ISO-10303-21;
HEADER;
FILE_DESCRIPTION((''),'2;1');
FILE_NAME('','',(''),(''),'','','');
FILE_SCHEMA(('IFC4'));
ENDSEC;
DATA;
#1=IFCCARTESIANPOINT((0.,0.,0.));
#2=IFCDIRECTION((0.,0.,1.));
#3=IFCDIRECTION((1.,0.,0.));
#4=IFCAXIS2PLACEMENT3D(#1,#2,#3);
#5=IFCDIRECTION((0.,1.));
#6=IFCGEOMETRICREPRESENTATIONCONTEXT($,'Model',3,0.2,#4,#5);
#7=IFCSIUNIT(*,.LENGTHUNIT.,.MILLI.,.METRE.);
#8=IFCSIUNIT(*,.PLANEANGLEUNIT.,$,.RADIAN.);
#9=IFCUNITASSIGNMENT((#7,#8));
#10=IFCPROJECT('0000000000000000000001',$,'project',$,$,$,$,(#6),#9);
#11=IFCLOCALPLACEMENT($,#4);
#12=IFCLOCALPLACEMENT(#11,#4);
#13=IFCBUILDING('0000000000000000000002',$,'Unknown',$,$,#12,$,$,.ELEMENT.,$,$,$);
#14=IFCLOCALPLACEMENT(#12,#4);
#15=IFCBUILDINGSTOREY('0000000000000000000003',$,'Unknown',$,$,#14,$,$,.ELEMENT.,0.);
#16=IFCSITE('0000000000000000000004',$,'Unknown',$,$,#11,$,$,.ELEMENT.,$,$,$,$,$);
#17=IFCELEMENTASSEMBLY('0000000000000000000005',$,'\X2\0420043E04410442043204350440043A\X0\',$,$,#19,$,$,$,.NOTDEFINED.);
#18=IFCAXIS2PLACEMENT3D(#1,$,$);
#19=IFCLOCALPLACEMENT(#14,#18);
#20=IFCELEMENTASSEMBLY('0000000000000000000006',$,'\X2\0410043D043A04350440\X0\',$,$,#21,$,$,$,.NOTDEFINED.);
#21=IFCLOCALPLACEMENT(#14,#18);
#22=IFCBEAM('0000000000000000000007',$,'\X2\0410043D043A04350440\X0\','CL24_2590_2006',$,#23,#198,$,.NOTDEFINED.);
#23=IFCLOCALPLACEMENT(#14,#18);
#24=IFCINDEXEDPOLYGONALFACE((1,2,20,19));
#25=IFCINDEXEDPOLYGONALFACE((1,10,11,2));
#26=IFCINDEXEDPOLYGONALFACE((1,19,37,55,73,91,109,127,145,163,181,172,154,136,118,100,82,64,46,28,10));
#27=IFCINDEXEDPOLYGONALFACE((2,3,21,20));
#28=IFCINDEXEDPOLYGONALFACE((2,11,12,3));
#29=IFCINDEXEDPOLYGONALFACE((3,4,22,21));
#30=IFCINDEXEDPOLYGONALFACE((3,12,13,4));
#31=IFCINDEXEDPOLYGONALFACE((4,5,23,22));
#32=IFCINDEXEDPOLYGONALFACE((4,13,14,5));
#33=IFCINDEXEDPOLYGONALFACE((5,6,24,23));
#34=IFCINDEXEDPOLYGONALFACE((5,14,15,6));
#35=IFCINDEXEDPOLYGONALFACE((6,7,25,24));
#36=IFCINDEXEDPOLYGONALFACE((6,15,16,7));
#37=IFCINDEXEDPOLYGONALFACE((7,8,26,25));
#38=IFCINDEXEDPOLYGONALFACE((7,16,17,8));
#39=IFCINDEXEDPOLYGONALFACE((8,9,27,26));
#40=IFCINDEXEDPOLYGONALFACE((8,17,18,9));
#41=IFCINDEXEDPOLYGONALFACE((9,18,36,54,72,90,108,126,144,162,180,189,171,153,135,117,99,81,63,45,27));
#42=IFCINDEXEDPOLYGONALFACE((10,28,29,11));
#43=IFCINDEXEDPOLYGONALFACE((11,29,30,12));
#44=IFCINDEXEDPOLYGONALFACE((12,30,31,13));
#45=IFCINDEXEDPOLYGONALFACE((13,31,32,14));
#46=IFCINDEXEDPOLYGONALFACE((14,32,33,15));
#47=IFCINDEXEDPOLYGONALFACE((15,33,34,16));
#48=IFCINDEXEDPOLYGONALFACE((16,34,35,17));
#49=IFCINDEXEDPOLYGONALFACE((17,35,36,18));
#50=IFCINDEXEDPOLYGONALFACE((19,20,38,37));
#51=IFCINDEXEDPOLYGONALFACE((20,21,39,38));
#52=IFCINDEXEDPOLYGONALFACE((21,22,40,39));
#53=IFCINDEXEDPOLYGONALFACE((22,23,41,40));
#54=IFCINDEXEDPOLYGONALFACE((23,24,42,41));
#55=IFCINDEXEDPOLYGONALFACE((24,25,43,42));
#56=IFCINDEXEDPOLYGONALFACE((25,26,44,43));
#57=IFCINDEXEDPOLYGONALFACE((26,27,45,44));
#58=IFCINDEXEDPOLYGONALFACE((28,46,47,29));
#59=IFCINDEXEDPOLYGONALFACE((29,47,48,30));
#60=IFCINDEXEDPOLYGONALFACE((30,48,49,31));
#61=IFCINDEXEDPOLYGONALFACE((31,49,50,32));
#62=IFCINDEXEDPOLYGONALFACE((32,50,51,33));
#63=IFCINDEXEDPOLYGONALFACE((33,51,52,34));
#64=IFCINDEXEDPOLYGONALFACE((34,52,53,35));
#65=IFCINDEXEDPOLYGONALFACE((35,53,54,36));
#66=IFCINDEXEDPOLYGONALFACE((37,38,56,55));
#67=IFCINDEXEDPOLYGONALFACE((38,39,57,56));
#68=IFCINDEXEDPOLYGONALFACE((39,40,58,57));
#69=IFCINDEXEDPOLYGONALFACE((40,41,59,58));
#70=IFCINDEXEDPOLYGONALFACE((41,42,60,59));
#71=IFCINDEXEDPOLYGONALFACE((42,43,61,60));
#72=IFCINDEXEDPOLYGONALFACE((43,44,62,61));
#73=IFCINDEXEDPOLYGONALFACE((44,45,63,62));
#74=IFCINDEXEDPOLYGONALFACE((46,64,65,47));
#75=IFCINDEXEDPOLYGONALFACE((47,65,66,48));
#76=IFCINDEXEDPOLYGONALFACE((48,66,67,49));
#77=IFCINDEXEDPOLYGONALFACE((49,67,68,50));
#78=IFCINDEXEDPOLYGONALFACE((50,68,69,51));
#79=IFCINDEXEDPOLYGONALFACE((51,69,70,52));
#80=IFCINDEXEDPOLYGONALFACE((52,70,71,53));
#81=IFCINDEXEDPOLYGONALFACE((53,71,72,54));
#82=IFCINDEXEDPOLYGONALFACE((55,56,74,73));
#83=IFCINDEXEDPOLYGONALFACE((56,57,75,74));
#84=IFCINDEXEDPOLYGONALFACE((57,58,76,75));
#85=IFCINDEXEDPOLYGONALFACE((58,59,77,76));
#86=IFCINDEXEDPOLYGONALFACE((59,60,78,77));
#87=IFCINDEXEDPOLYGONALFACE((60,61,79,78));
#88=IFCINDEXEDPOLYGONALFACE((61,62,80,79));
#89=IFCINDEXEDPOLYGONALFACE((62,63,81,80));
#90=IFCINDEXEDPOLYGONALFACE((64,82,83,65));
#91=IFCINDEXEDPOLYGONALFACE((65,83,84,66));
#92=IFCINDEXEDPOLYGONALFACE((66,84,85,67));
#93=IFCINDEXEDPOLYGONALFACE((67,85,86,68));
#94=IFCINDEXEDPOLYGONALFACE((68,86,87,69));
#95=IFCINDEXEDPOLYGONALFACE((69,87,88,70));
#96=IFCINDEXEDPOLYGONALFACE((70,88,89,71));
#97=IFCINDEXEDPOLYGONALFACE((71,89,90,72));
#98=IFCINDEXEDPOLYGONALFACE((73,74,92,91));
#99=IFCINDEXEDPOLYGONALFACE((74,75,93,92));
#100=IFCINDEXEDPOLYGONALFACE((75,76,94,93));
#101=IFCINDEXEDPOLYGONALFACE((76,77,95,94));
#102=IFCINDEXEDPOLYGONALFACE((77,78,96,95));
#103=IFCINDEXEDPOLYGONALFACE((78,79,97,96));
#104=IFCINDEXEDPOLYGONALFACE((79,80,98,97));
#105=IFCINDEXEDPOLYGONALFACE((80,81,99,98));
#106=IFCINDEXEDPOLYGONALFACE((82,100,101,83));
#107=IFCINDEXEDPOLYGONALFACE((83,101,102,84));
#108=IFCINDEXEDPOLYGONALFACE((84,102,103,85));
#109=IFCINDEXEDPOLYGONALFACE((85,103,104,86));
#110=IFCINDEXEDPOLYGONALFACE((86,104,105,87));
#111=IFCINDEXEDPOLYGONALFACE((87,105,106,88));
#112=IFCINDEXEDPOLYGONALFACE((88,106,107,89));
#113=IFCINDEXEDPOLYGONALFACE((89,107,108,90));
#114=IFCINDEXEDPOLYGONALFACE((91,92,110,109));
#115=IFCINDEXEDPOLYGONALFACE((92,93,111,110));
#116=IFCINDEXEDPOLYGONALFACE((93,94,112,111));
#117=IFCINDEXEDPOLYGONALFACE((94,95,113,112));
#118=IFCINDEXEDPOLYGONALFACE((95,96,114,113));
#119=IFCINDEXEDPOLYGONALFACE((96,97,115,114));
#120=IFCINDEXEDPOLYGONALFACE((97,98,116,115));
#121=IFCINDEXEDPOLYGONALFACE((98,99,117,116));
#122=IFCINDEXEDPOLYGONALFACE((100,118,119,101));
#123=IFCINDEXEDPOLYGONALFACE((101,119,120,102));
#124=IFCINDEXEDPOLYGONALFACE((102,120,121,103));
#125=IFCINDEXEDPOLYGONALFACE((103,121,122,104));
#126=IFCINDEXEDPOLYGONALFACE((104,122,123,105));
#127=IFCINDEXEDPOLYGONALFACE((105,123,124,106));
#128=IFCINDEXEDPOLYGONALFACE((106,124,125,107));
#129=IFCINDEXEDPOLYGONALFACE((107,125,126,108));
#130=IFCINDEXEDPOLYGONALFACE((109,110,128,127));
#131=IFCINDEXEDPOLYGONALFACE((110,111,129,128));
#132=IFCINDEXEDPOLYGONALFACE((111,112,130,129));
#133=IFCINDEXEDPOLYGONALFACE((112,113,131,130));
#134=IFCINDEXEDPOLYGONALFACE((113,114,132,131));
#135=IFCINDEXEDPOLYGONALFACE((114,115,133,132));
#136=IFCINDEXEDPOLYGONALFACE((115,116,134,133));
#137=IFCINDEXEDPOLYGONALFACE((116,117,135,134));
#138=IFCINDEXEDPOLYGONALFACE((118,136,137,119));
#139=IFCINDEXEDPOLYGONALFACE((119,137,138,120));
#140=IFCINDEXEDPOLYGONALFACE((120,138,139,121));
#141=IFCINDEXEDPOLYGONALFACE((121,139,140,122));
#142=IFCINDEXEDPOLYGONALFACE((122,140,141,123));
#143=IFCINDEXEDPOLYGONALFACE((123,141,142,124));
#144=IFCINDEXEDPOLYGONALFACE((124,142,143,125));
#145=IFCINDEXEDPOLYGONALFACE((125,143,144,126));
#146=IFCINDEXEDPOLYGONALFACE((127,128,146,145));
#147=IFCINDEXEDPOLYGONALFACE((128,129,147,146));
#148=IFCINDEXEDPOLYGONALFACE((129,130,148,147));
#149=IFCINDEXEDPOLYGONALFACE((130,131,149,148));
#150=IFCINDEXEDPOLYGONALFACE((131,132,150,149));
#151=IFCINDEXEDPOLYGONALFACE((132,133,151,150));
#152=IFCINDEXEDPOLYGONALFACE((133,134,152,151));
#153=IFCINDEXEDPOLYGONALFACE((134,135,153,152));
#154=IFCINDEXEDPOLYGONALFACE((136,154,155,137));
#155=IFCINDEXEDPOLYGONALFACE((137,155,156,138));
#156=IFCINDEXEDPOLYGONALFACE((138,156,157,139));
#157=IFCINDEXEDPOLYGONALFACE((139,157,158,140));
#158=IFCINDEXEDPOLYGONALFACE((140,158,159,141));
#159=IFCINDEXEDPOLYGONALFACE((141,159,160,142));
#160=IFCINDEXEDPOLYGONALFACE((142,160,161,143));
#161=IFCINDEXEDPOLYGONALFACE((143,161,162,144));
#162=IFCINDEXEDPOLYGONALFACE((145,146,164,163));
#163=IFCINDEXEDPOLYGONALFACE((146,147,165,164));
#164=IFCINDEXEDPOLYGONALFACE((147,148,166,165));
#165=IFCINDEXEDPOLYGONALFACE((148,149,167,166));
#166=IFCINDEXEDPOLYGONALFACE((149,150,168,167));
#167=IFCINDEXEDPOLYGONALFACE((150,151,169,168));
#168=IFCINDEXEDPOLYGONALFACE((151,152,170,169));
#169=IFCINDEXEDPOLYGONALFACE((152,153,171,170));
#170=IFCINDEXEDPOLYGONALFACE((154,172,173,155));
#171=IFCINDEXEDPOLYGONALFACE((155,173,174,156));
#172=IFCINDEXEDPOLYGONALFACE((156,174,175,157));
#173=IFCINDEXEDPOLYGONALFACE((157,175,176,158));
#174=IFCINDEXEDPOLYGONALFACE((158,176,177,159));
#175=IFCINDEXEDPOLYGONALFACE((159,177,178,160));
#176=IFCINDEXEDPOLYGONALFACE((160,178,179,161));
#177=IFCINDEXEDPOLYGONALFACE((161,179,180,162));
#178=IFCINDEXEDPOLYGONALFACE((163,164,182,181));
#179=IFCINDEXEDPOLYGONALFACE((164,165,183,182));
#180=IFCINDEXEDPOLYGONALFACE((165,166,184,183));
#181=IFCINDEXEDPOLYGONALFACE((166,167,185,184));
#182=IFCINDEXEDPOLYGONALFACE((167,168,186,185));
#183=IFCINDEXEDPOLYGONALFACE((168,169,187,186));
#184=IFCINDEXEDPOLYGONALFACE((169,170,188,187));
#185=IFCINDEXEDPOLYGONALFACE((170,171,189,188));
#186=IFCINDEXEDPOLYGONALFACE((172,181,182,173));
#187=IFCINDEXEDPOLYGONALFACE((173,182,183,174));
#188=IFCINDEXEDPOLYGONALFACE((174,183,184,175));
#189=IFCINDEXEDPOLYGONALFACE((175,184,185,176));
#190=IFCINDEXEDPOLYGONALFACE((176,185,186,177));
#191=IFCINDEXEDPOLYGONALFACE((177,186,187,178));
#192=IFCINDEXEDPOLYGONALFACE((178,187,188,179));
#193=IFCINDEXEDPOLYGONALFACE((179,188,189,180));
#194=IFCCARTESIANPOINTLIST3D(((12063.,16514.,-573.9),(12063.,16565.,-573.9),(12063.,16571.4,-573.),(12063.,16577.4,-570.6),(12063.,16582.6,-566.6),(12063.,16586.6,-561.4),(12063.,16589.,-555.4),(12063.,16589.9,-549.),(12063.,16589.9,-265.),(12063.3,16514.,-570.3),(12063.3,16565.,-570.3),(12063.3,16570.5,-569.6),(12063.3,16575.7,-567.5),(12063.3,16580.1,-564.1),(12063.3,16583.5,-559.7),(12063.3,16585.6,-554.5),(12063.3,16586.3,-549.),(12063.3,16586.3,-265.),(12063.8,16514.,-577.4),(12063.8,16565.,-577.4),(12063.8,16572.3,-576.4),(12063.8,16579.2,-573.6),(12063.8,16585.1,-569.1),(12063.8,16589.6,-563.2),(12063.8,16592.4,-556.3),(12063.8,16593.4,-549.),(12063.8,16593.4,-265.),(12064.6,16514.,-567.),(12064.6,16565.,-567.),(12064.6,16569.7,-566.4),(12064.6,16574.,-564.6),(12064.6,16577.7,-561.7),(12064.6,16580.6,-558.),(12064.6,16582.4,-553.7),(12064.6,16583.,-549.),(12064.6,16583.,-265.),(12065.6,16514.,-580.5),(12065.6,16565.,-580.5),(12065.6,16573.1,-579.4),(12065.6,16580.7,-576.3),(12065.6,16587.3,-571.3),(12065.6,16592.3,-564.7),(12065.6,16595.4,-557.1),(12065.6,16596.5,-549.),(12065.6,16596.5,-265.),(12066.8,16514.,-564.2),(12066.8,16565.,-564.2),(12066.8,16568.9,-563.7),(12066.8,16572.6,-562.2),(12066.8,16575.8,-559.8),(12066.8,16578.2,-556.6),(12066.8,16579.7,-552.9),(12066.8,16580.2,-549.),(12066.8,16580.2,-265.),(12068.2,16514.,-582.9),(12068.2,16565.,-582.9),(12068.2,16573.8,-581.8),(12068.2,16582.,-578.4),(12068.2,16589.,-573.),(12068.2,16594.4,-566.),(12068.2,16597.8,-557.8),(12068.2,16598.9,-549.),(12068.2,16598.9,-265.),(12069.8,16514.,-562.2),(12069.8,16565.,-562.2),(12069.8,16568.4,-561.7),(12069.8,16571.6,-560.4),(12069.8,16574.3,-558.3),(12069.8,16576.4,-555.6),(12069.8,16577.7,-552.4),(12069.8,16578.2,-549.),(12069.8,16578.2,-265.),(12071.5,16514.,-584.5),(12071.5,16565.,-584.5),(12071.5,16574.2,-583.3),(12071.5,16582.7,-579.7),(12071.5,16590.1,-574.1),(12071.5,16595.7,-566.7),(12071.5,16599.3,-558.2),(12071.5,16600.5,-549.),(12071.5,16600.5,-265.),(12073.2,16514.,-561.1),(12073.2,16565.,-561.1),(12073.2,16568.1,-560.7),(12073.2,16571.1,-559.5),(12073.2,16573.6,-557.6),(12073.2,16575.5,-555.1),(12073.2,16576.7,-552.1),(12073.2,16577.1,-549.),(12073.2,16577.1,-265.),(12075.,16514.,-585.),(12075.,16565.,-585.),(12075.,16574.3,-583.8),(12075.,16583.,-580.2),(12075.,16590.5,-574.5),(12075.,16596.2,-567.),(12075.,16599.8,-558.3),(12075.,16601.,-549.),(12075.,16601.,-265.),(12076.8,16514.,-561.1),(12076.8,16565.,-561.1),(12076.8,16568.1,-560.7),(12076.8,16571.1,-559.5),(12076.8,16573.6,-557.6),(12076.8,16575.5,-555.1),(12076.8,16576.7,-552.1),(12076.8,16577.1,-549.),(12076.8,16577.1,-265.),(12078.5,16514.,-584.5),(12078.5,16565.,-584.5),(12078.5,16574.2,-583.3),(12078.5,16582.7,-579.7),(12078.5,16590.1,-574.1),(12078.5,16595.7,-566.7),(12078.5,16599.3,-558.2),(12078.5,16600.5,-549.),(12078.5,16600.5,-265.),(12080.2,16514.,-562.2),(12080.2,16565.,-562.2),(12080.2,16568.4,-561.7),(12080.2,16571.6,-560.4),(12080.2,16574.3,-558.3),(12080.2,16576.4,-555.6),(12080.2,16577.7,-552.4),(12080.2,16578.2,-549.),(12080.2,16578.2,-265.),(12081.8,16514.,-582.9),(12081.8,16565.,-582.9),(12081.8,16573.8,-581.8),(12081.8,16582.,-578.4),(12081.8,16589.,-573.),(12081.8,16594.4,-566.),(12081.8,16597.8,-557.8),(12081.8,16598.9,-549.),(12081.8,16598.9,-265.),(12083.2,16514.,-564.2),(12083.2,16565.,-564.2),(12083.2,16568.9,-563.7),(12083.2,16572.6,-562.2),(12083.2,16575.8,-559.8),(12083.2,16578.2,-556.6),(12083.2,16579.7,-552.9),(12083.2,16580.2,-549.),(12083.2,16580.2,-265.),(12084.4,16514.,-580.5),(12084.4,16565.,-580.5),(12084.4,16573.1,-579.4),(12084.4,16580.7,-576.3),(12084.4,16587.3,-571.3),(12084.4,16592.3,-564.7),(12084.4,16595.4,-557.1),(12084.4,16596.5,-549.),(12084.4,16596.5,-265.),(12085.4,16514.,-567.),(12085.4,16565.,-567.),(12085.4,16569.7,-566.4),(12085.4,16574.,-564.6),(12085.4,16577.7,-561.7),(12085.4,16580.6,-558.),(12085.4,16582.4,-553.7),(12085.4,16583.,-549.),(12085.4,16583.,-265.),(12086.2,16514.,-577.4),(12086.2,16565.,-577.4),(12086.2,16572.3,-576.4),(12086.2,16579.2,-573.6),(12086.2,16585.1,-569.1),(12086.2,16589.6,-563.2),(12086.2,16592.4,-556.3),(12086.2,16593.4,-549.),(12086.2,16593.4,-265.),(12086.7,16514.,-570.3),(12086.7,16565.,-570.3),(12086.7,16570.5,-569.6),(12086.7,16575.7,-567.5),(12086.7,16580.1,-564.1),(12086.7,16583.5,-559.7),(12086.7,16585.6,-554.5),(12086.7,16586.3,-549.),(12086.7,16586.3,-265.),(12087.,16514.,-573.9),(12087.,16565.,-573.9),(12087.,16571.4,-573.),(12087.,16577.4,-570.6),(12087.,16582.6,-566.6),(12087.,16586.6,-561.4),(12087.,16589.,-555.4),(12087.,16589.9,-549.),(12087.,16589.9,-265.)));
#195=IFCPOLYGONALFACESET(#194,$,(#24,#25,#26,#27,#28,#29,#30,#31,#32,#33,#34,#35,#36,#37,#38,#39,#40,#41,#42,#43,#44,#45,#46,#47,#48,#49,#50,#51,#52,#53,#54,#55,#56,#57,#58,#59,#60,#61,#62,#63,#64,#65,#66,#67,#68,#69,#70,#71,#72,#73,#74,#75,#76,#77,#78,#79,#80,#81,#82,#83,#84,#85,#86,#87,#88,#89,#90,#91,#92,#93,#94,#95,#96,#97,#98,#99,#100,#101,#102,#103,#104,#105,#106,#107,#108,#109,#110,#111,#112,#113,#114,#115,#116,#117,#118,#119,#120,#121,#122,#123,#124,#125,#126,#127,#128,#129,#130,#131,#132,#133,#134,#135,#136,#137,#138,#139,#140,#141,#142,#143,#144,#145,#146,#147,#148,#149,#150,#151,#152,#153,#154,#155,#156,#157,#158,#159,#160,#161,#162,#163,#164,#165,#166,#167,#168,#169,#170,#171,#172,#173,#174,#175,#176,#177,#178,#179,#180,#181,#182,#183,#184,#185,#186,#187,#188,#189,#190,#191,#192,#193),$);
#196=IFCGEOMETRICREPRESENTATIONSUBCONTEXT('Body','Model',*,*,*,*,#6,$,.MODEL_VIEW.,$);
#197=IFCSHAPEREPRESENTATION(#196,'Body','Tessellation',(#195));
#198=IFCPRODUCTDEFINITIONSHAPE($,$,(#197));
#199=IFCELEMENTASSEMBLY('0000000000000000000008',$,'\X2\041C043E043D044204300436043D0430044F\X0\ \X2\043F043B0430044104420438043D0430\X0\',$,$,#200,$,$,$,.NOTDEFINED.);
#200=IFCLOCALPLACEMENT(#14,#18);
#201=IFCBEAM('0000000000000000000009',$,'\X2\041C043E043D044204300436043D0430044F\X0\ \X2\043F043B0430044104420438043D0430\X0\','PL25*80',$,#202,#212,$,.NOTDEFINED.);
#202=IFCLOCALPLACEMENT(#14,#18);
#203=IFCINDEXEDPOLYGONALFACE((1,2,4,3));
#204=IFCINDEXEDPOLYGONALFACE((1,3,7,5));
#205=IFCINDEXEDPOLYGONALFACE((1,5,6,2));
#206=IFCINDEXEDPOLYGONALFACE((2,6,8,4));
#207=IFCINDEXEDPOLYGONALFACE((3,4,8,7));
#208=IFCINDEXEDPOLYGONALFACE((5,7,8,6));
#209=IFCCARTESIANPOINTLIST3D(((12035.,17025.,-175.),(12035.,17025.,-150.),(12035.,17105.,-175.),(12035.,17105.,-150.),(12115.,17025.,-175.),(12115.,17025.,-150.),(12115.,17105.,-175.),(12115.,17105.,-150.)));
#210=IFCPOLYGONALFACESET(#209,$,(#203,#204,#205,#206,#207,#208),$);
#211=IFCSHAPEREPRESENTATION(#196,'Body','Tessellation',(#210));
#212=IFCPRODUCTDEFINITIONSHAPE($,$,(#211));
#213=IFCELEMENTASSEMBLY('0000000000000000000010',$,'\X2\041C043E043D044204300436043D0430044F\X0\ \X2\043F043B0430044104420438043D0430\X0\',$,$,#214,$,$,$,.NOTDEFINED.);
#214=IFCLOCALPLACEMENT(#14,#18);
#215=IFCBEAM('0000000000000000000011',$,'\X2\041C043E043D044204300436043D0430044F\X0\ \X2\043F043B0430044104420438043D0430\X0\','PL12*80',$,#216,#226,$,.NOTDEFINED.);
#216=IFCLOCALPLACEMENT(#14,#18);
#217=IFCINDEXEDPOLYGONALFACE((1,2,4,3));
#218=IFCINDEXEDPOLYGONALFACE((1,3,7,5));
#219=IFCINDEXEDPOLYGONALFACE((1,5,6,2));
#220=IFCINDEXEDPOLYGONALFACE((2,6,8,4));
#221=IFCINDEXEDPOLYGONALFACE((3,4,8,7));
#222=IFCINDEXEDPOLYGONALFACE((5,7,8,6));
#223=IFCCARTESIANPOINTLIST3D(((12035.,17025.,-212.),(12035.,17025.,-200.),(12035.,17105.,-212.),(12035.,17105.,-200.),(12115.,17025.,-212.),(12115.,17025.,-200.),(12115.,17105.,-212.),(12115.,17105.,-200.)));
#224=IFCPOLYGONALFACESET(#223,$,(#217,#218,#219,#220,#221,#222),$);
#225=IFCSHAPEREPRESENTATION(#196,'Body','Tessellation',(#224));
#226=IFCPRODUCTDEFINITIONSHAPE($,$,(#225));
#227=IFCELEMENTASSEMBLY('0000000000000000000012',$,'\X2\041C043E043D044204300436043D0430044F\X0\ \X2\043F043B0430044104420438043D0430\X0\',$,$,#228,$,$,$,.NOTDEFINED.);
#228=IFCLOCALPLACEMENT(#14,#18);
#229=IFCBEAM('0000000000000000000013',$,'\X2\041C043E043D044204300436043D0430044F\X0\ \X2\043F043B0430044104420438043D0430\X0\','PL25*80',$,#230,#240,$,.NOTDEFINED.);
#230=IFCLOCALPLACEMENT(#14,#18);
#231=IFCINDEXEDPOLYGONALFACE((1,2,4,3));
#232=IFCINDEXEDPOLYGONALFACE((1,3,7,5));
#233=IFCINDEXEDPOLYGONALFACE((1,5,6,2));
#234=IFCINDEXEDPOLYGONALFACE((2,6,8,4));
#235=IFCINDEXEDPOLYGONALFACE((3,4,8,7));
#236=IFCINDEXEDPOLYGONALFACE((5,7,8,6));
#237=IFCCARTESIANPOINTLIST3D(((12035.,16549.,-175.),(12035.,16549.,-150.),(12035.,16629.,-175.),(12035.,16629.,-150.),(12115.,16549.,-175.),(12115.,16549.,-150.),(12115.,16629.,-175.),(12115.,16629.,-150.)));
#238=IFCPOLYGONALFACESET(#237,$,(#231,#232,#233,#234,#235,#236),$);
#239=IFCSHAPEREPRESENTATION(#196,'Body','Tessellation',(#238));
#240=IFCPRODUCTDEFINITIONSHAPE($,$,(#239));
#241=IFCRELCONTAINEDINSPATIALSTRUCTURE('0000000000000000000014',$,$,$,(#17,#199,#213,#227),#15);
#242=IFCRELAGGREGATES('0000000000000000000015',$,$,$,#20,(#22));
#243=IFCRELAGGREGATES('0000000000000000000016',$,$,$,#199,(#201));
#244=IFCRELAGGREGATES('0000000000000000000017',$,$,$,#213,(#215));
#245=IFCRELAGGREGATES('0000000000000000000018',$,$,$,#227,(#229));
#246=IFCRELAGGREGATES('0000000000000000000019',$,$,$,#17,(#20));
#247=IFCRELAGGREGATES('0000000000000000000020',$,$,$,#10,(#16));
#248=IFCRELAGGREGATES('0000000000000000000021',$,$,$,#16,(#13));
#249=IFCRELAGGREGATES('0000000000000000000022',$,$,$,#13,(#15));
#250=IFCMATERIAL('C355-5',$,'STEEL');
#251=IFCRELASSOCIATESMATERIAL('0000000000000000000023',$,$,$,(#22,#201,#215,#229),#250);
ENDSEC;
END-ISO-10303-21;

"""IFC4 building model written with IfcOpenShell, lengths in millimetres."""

from ifc_helpers import new_model, entity, si_unit, direction, frame, origin_with_axes, place, context, subcontext, project, spatial, line, indexed_curve, outline, extrude, material, element, aggregate, save


model = new_model("IFC4")

# Units and contexts
model_context = context("Model", 3, precision=0.2, world=origin_with_axes(), true_north=direction((0.0, 1.0)))
body_context = subcontext(model_context, "Body", "Model", "MODEL_VIEW")
ifc_project = project(units=[si_unit("LENGTHUNIT", "METRE", prefix="MILLI"), si_unit("PLANEANGLEUNIT", "RADIAN")], contexts=[model_context])

# Site, building, storey
site_placement = place(None, origin_with_axes())
site = spatial("IfcSite", under=ifc_project, at=site_placement, Name="Unknown", CompositionType="ELEMENT")
building_placement = place(site_placement, origin_with_axes())
building = spatial("IfcBuilding", under=site, at=building_placement, Name="Unknown", CompositionType="ELEMENT")
storey_placement = place(building_placement, origin_with_axes())
storey = spatial("IfcBuildingStorey", under=building, at=storey_placement, Name="Unknown", CompositionType="ELEMENT", Elevation=0.0)

# Element assembly
assembly_1_placement = place(storey_placement, frame((12000.0, 16827.0, -300.0), z_axis=(-1.0, 0.0, 0.0), x_axis=(0.0, 0.0, -1.0)))
assembly_1 = element("IfcElementAssembly", 1, at=assembly_1_placement, inside=storey, Name="Ростверк", PredefinedType="NOTDEFINED")

# Element assembly, beam, voiding feature
ifc_material_1 = material(Name="C355-5", Category="STEEL")
assembly_2_placement = place(assembly_1_placement, frame((-215.0, 238.0, -75.0), z_axis=(0.0, -1.0, 0.0), x_axis=(1.0, 0.0, 0.0)))
assembly_2 = element("IfcElementAssembly", 2, at=assembly_2_placement, Name="Анкер", PredefinedType="NOTDEFINED")
beam_1_placement = place(assembly_2_placement, origin_with_axes())
beam_1 = element("IfcBeam", 3, at=beam_1_placement, material=ifc_material_1, Name="Анкер", Description="CL24_2590_2006", PredefinedType="NOTDEFINED", context=body_context, shape_type="SolidModel", body=[
    entity("IfcSweptDiskSolid", entity("IfcIndexedPolyCurve", entity("IfcCartesianPointList3D", [[0.0, 0.0, 0.0], [464.0, 0.0, 0.0], [481.0, 0.0, -7.0], [488.0, 0.0, -24.0], [488.0, 0.0, -75.0]]), [entity("IfcLineIndex", [1, 2]), entity("IfcArcIndex", [2, 3, 4]), entity("IfcLineIndex", [4, 5])]), 12.0),
])
voiding_feature_1_placement = place(beam_1_placement, frame((0.0, 0.0, 0.0), z_axis=(0.0, -1.0, 0.0), x_axis=(1.0, 0.0, 0.0)))
element("IfcVoidingFeature", 4, at=voiding_feature_1_placement, cuts=beam_1, Name="Анкер", PredefinedType="HOLE", context=body_context, shape_type="SolidModel", body=[
    extrude(outline(indexed_curve([(12.5, 0.0), (12.2, 2.8), (11.3, 5.4), (9.8, 7.8), (7.8, 9.8), (5.4, 11.3), (2.8, 12.2), (0.0, 12.5), (-2.8, 12.2), (-5.4, 11.3), (-7.8, 9.8), (-9.8, 7.8), (-11.3, 5.4), (-12.2, 2.8), (-12.5, 0.0), (-12.2, -2.8), (-11.3, -5.4), (-9.8, -7.8), (-7.8, -9.8), (-5.4, -11.3), (-2.8, -12.2), (0.0, -12.5), (2.8, -12.2), (5.4, -11.3), (7.8, -9.8), (9.8, -7.8), (11.3, -5.4), (12.2, -2.8)], segments=[line(1, 2, 3, 4, 5, 6, 7, 8, 9, 10, 11, 12, 13, 14, 15, 16, 17, 18, 19, 20, 21, 22, 23, 24, 25, 26, 27, 28, 1)])), frame((0.0, 0.0, 0.0), z_axis=(-1.0, 0.0, 0.0), x_axis=(0.0, 0.0, 1.0)), (0.0, 0.0, -1.0), 180.0),
])
aggregate(assembly_2, [beam_1])

# Element assemblies, beams
assembly_3_placement = place(storey_placement, frame((12115.0, 17065.0, -162.5), z_axis=(0.0, 0.0, -1.0), x_axis=(-1.0, 0.0, 0.0)))
assembly_3 = element("IfcElementAssembly", 5, at=assembly_3_placement, inside=storey, Name="Монтажная пластина", PredefinedType="NOTDEFINED")
beam_2_placement = place(assembly_3_placement, origin_with_axes())
beam_2 = element("IfcBeam", 6, at=beam_2_placement, material=ifc_material_1, Name="Монтажная пластина", Description="PL25*80", PredefinedType="NOTDEFINED", context=body_context, shape_type="SolidModel", body=[
    extrude(outline(indexed_curve([(-12.5, -40.0), (12.5, -40.0), (12.5, 40.0), (-12.5, 40.0)], segments=[line(1, 2, 3, 4, 1)])), frame((0.0, 0.0, 0.0), z_axis=(-1.0, 0.0, 0.0), x_axis=(0.0, 0.0, 1.0)), (0.0, 0.0, -1.0), 80.0),
])
aggregate(assembly_3, [beam_2])
assembly_4_placement = place(storey_placement, frame((12115.0, 17065.0, -206.0), z_axis=(0.0, 0.0, -1.0), x_axis=(-1.0, 0.0, 0.0)))
assembly_4 = element("IfcElementAssembly", 7, at=assembly_4_placement, inside=storey, Name="Монтажная пластина", PredefinedType="NOTDEFINED")
beam_3_placement = place(assembly_4_placement, origin_with_axes())
beam_3 = element("IfcBeam", 8, at=beam_3_placement, material=ifc_material_1, Name="Монтажная пластина", Description="PL12*80", PredefinedType="NOTDEFINED", context=body_context, shape_type="SolidModel", body=[
    extrude(outline(indexed_curve([(-6.0, -40.0), (6.0, -40.0), (6.0, 40.0), (-6.0, 40.0)], segments=[line(1, 2, 3, 4, 1)])), frame((0.0, 0.0, 0.0), z_axis=(-1.0, 0.0, 0.0), x_axis=(0.0, 0.0, 1.0)), (0.0, 0.0, -1.0), 80.0),
])
aggregate(assembly_4, [beam_3])
assembly_5_placement = place(storey_placement, frame((12115.0, 16589.0, -162.5), z_axis=(0.0, 0.0, -1.0), x_axis=(-1.0, 0.0, 0.0)))
assembly_5 = element("IfcElementAssembly", 9, at=assembly_5_placement, inside=storey, Name="Монтажная пластина", PredefinedType="NOTDEFINED")
beam_4_placement = place(assembly_5_placement, origin_with_axes())
beam_4 = element("IfcBeam", 10, at=beam_4_placement, material=ifc_material_1, Name="Монтажная пластина", Description="PL25*80", PredefinedType="NOTDEFINED", context=body_context, shape_type="SolidModel", body=[
    extrude(outline(indexed_curve([(-12.5, -40.0), (12.5, -40.0), (12.5, 40.0), (-12.5, 40.0)], segments=[line(1, 2, 3, 4, 1)])), frame((0.0, 0.0, 0.0), z_axis=(-1.0, 0.0, 0.0), x_axis=(0.0, 0.0, 1.0)), (0.0, 0.0, -1.0), 80.0),
])
aggregate(assembly_5, [beam_4])

aggregate(assembly_1, [assembly_2])

save(model, "model.ifc")
